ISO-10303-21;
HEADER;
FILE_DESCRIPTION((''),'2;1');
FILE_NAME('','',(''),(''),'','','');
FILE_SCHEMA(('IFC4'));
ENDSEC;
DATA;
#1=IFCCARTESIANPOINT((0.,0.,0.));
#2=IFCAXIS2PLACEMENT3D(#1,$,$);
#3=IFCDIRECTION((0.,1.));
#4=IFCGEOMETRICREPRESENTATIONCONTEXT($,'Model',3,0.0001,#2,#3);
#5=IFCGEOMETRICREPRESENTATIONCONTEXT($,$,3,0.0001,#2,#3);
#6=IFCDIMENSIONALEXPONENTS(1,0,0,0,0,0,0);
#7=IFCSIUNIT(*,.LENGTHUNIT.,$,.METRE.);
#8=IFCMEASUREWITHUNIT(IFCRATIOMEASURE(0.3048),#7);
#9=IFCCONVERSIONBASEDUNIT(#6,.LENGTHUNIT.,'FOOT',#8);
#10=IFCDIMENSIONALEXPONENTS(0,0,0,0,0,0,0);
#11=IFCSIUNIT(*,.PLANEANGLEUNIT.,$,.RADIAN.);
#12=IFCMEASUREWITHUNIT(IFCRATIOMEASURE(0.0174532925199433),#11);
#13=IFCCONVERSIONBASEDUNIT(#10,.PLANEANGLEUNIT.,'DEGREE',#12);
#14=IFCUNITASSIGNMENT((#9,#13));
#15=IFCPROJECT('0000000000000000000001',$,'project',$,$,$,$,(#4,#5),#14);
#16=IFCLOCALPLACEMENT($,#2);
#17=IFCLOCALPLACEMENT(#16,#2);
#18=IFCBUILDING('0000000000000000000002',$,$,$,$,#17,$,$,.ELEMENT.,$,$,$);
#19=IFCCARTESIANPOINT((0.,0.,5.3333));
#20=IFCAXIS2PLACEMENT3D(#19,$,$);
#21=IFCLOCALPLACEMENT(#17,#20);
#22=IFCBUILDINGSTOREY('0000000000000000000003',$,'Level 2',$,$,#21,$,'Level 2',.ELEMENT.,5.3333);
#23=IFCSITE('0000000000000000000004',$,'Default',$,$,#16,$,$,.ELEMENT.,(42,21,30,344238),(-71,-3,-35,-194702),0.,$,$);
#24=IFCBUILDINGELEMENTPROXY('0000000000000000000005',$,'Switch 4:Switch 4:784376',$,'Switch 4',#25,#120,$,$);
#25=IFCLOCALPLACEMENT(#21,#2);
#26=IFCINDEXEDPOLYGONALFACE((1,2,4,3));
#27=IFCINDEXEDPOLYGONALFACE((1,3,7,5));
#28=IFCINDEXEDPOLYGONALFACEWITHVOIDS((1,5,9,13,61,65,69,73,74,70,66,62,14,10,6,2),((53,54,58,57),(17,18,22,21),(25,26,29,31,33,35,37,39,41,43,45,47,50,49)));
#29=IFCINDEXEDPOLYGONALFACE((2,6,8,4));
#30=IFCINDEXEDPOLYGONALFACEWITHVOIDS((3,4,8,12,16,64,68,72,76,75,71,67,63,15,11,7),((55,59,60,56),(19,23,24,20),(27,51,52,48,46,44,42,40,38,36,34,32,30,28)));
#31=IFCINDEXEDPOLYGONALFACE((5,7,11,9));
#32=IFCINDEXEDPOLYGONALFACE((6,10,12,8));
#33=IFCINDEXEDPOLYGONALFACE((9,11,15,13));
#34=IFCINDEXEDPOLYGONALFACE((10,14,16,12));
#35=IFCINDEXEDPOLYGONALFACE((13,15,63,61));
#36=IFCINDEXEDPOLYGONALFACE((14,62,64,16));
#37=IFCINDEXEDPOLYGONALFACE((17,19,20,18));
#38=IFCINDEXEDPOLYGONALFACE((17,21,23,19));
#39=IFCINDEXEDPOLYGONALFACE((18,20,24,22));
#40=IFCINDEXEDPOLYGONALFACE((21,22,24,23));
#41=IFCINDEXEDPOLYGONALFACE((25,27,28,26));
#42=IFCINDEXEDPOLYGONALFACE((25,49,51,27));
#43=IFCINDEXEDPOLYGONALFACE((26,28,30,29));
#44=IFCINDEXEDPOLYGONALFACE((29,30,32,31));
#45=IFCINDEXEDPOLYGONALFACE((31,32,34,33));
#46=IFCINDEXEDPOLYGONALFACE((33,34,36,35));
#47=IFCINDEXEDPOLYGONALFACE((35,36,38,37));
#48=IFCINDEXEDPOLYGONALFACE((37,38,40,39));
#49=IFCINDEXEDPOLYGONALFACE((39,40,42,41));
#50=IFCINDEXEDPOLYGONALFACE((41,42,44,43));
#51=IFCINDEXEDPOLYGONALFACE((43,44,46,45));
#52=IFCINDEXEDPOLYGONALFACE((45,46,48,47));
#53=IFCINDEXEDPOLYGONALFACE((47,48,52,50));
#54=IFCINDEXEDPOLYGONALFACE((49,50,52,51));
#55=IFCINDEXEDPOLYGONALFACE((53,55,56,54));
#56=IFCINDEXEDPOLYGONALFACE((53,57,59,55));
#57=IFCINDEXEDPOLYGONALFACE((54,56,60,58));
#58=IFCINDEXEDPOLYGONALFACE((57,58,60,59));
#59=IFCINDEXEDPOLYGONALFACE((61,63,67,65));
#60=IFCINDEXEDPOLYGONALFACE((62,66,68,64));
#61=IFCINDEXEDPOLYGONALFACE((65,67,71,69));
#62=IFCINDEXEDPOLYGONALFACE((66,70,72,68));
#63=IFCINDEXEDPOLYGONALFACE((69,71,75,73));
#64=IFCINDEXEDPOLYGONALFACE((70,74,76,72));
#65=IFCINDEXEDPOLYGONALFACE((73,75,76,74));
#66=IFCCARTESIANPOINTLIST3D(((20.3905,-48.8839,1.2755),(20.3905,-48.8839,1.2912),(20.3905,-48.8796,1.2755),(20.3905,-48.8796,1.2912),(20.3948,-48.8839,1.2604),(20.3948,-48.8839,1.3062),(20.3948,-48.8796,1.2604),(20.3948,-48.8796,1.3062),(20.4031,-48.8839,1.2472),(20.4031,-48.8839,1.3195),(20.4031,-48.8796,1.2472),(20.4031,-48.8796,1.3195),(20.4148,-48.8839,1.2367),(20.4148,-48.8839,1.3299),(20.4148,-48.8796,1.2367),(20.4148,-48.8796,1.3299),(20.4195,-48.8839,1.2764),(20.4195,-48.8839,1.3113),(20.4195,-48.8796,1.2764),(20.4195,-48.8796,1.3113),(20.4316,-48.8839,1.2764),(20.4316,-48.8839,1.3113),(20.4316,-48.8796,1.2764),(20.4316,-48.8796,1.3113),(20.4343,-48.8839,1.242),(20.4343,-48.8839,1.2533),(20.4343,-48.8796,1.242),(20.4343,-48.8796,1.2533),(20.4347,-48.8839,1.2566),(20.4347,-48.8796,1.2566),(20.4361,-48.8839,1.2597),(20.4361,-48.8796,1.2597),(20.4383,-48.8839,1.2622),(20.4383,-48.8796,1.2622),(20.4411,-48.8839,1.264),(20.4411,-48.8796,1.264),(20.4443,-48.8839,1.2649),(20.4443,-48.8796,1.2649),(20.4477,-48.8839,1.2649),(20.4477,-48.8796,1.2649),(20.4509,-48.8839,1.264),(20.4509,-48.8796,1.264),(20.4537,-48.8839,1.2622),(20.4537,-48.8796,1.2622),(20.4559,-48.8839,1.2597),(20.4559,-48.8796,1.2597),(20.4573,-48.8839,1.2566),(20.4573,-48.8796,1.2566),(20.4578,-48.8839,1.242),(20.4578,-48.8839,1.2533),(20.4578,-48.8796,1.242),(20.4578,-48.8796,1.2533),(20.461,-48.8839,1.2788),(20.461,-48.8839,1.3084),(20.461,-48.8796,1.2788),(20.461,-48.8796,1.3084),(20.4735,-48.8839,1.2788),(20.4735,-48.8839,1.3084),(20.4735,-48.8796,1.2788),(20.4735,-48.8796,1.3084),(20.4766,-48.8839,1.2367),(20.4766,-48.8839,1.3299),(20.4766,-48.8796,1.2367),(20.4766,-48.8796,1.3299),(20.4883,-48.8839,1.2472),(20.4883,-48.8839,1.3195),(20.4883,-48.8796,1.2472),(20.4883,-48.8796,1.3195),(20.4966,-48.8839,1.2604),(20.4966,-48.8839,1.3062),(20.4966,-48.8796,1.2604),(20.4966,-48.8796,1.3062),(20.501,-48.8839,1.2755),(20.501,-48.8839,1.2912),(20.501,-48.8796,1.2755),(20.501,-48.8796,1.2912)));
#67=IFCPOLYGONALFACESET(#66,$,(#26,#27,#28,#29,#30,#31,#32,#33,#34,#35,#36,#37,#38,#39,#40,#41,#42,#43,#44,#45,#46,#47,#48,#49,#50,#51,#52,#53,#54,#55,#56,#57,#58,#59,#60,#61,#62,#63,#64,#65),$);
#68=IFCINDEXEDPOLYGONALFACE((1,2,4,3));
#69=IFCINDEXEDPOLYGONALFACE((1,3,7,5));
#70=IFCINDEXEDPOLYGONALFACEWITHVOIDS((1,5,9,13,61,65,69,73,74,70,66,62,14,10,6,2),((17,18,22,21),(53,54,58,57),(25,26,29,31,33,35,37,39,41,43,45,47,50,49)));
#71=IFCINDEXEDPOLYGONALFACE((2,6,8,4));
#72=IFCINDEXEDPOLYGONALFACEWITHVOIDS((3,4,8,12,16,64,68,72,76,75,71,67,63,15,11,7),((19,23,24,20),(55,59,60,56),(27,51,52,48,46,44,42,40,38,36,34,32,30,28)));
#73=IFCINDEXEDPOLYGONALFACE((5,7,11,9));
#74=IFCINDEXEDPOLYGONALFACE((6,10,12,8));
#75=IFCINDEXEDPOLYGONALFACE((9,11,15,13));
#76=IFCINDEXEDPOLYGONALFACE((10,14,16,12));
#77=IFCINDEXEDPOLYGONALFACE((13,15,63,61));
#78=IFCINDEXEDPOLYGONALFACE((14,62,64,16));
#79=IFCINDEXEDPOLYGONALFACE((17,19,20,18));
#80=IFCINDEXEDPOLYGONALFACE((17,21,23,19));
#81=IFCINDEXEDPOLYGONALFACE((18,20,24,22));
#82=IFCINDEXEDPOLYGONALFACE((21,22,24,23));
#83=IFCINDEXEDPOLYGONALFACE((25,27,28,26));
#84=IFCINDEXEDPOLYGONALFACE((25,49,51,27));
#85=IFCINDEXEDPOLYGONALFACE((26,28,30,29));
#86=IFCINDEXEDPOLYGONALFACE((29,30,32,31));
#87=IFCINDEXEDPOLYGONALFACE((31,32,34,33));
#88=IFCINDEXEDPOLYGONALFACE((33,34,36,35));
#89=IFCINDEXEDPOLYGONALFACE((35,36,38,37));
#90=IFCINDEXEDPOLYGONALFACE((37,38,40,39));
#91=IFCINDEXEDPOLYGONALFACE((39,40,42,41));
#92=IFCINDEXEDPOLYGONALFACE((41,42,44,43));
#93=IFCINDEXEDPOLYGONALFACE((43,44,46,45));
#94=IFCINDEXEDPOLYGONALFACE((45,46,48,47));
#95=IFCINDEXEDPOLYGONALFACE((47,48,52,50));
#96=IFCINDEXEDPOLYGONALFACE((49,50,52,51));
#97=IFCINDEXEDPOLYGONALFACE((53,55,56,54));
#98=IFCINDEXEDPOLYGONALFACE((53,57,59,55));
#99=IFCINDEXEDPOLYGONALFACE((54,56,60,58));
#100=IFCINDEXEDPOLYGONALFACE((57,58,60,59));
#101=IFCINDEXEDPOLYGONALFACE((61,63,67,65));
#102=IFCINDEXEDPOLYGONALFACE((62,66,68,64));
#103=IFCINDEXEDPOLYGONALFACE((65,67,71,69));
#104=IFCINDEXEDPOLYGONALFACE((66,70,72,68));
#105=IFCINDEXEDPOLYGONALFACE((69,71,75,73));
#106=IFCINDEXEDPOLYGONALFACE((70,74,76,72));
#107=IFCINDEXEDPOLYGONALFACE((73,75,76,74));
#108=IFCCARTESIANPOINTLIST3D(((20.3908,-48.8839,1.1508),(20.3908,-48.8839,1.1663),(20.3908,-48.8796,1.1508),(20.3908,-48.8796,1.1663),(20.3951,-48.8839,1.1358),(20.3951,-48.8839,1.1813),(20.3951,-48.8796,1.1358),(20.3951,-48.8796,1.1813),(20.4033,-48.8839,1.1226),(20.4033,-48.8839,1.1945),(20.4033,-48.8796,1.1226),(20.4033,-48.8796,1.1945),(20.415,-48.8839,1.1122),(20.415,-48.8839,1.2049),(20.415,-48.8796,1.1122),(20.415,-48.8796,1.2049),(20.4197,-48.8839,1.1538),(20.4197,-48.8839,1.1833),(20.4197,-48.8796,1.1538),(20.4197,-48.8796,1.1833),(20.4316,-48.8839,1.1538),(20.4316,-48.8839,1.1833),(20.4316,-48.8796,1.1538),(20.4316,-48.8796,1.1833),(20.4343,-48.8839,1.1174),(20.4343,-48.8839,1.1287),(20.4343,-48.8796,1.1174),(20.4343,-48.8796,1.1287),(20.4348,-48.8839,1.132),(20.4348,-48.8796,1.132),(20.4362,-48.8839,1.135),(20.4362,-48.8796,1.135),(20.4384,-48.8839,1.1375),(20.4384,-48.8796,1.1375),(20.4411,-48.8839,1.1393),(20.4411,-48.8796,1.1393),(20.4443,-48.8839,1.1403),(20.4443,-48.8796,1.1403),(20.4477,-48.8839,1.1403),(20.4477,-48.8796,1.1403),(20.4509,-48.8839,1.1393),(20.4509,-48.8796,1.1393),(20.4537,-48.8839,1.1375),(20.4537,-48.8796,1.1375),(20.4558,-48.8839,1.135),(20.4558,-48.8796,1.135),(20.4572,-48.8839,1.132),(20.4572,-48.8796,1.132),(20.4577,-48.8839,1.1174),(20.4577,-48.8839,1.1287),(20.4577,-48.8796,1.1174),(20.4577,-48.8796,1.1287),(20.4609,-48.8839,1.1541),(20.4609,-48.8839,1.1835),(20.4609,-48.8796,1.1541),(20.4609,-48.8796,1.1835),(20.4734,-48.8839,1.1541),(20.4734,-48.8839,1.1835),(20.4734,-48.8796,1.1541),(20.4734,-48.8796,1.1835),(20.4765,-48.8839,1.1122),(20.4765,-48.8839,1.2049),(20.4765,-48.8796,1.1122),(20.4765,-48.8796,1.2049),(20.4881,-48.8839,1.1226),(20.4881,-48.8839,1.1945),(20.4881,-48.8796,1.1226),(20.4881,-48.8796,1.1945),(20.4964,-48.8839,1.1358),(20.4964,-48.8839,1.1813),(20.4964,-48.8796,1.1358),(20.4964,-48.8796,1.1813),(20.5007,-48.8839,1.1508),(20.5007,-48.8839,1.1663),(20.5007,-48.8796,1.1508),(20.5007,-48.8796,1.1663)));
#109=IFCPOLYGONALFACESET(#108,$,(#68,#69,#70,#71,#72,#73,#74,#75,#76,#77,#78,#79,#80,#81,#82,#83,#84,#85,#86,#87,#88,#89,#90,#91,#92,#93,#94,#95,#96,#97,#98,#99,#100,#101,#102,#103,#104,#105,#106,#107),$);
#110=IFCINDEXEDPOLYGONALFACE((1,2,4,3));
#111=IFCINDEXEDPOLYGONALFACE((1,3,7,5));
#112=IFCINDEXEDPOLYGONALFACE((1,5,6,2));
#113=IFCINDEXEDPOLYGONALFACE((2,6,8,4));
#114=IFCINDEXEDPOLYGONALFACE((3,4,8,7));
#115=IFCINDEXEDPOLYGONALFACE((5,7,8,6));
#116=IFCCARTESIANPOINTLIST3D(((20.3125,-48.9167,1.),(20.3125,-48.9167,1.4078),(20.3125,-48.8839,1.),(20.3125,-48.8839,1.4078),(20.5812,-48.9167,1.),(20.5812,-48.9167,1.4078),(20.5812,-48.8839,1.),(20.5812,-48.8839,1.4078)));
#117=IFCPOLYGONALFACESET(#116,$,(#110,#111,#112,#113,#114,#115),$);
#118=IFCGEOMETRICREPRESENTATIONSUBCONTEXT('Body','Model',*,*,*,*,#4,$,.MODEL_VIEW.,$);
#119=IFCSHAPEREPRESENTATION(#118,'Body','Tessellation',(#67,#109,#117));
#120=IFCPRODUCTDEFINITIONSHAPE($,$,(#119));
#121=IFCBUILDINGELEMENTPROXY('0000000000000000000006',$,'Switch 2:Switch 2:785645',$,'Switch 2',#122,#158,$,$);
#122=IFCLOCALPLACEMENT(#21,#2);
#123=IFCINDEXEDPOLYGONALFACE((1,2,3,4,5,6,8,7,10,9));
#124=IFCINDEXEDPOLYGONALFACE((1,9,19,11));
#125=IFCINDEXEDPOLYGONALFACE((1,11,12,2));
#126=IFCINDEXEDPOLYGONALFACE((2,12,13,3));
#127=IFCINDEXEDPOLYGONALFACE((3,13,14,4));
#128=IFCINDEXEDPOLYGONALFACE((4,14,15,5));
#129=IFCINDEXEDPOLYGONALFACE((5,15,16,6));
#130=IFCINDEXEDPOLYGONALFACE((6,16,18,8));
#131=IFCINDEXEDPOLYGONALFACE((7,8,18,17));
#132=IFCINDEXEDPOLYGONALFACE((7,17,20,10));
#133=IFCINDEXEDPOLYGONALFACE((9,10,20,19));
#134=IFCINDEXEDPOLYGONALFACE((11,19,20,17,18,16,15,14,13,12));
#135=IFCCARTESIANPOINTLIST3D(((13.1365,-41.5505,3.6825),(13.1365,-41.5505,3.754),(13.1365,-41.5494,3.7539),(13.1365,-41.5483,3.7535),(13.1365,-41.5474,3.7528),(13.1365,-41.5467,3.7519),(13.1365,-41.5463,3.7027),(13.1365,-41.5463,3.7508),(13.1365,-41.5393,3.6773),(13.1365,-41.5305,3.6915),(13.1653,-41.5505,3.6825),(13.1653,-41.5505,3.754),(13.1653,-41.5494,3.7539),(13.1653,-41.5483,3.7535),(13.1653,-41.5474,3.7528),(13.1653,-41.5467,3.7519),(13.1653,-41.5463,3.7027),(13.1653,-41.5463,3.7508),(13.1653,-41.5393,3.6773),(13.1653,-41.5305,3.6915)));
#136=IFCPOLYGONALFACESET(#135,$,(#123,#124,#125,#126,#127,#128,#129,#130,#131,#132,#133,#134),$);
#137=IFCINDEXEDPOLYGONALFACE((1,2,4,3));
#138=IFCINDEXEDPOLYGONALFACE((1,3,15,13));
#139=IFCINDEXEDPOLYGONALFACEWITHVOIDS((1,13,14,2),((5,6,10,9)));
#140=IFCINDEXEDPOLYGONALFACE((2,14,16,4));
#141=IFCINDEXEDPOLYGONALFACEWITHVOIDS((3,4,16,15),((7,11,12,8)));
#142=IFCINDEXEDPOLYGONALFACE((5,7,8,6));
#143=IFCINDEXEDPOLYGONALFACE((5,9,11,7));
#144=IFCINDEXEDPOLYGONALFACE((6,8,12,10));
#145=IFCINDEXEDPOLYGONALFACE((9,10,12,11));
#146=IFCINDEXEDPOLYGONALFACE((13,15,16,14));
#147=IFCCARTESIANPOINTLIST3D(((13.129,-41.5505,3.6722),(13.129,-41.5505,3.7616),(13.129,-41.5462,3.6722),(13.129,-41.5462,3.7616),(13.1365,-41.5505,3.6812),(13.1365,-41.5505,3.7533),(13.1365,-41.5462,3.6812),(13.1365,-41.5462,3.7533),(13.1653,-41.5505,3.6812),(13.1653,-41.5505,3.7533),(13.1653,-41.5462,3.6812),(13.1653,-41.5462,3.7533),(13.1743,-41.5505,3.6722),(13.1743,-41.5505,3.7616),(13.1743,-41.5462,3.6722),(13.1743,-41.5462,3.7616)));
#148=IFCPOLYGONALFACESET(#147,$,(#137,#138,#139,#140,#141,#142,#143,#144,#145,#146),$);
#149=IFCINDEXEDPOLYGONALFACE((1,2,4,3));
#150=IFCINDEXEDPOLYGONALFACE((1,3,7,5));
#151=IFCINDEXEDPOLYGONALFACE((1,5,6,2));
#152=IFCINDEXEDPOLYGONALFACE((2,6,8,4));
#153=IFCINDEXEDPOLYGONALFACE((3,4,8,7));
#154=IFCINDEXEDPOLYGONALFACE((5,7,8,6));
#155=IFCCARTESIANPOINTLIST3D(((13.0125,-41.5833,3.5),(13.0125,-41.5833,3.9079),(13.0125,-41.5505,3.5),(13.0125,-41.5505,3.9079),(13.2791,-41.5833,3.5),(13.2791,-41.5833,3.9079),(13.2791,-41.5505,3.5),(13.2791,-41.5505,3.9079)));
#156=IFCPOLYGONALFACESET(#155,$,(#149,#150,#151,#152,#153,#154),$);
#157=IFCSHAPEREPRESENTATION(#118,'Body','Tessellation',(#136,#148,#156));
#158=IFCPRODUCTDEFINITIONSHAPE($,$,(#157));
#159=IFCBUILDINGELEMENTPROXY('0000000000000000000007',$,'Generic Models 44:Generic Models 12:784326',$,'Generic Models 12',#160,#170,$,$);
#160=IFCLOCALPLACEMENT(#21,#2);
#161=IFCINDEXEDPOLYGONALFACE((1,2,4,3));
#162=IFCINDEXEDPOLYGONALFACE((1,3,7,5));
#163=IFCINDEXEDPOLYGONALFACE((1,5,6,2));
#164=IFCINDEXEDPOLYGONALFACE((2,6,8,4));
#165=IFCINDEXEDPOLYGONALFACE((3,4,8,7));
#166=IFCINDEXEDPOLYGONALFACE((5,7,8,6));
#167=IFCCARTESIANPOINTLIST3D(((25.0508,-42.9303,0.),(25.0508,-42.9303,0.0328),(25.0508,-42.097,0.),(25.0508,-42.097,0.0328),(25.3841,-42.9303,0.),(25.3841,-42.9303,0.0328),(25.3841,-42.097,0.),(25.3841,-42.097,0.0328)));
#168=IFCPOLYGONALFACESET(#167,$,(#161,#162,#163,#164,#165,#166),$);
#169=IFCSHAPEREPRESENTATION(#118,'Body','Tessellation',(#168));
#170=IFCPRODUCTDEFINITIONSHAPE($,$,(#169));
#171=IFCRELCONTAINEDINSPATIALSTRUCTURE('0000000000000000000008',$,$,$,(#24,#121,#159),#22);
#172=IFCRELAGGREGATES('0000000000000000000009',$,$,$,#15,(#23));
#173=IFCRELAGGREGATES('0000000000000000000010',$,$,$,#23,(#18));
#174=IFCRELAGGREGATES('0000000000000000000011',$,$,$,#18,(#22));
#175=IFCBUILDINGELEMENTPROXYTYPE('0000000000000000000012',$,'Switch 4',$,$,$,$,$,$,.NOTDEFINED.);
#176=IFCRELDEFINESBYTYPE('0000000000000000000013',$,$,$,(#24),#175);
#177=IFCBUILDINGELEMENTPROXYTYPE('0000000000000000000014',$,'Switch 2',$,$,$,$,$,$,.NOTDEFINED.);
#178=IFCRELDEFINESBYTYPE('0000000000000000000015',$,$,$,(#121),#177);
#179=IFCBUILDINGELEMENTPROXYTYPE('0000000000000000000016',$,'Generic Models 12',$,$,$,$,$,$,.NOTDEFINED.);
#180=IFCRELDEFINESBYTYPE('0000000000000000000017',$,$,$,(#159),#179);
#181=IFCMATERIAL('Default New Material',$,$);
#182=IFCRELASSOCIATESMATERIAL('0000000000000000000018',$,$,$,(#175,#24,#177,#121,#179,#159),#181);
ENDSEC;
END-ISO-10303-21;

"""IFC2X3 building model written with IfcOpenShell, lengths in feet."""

from ifc_helpers import new_model, entity, si_unit, converted_unit, direction, frame, frame_2d, origin, origin_2d_with_axis, place, context, subcontext, project, spatial, polyline, circle_curve, parameter, trimmed, segment, composite_curve, rectangle, outline, extrude, source, transform, mapped, material, type_object, type_shapes, element, save


model = new_model("IFC2X3")

# Units and contexts
model_context = context("Model", 3, precision=0.0001, world=origin(), true_north=direction((0.0, 1.0)))
context_of_model = context(None, 3, precision=0.0001, world=origin(), true_north=direction((0.0, 1.0)))
body_context = subcontext(model_context, "Body", "Model", "MODEL_VIEW")
ifc_project = project(units=[converted_unit("LENGTHUNIT", "FOOT", entity("IfcRatioMeasure", 0.3048), si_unit("LENGTHUNIT", "METRE"), dimensions=[1, 0, 0, 0, 0, 0, 0]), converted_unit("PLANEANGLEUNIT", "DEGREE", entity("IfcRatioMeasure", 0.0174532925199433), si_unit("PLANEANGLEUNIT", "RADIAN"), dimensions=[0, 0, 0, 0, 0, 0, 0])], contexts=[model_context, context_of_model])

# Site, building, storey
site_placement = place(None, origin())
site = spatial("IfcSite", under=ifc_project, at=site_placement, Name="Default", CompositionType="ELEMENT", RefLatitude=(42, 21, 30, 344238), RefLongitude=(-71, -3, -35, -194702), RefElevation=0.0)
building_placement = place(site_placement, origin())
building = spatial("IfcBuilding", under=site, at=building_placement, CompositionType="ELEMENT")
storey_placement = place(building_placement, frame((0.0, 0.0, 5.3333)))
storey = spatial("IfcBuildingStorey", under=building, at=storey_placement, Name="Level 2", LongName="Level 2", CompositionType="ELEMENT", Elevation=5.3333)

# Shared definitions
ifc_material_1 = material(Name="Default New Material")

# Building element proxies
building_element_proxy_type_1 = type_object("IfcBuildingElementProxyType", Name="Switch 4", PredefinedType="NOTDEFINED", material=ifc_material_1)
shared_shape_1 = source(origin(), body_context, "Body", "SweptSolid", [
    extrude(outline(composite_curve([segment(polyline([(-0.0309, -0.0466), (0.0309, -0.0466)]), True, "CONTINUOUS"), segment(trimmed(circle_curve(frame_2d((-0.0003, 0.0), x_axis=(-1.0, 0.0)), 0.0561), [parameter(123.794741)], [parameter(236.205259)], True, "PARAMETER"), True, "CONTINUOUS"), segment(polyline([(0.0309, 0.0466), (-0.0309, 0.0466)]), True, "CONTINUOUS"), segment(trimmed(circle_curve(frame_2d((0.0003, 0.0), x_axis=(1.0, 0.0)), 0.0561), [parameter(123.794741)], [parameter(236.205259)], True, "PARAMETER"), True, "CONTINUOUS")], self_intersect=False), holes=[polyline([(0.0142, 0.0279), (0.0262, 0.0279), (0.0262, -0.0069), (0.0142, -0.0069), (0.0142, 0.0279)]), polyline([(-0.0153, 0.025), (-0.0153, -0.0045), (-0.0278, -0.0045), (-0.0278, 0.025), (-0.0153, 0.025)]), composite_curve([segment(polyline([(-0.012, -0.0413), (-0.012, -0.03)]), True, "CONTINUOUS"), segment(trimmed(circle_curve(frame_2d((-0.0003, -0.03), x_axis=(-1.0, 0.0)), 0.0117), [parameter(180.0)], [parameter(0.0)], True, "PARAMETER"), False, "CONTINUOUS"), segment(polyline([(0.0115, -0.03), (0.0115, -0.0413)]), True, "CONTINUOUS"), segment(polyline([(0.0115, -0.0413), (-0.012, -0.0413)]), True, "CONTINUOUS")], self_intersect=False)]), frame((-0.0011, 0.0328, 0.2833), z_axis=(0.0, 1.0, 0.0), x_axis=(-1.0, 0.0, 0.0)), (0.0, 0.0, 1.0), 0.0042),
    extrude(outline(composite_curve([segment(polyline([(-0.0308, -0.0464), (0.0308, -0.0464)]), True, "CONTINUOUS"), segment(trimmed(circle_curve(frame_2d((-0.0003, 0.0), x_axis=(-1.0, 0.0)), 0.0558), [parameter(123.794741)], [parameter(236.205259)], True, "PARAMETER"), True, "CONTINUOUS"), segment(polyline([(0.0308, 0.0464), (-0.0308, 0.0464)]), True, "CONTINUOUS"), segment(trimmed(circle_curve(frame_2d((0.0003, 0.0), x_axis=(1.0, 0.0)), 0.0558), [parameter(123.794741)], [parameter(236.205259)], True, "PARAMETER"), True, "CONTINUOUS")], self_intersect=False), holes=[polyline([(0.0141, 0.0247), (0.026, 0.0247), (0.026, -0.0047), (0.0141, -0.0047), (0.0141, 0.0247)]), polyline([(-0.0152, 0.0249), (-0.0152, -0.0045), (-0.0277, -0.0045), (-0.0277, 0.0249), (-0.0152, 0.0249)]), composite_curve([segment(polyline([(-0.012, -0.0411), (-0.012, -0.0299)]), True, "CONTINUOUS"), segment(trimmed(circle_curve(frame_2d((-0.0003, -0.0299), x_axis=(-1.0, 0.0)), 0.0117), [parameter(180.0)], [parameter(0.0)], True, "PARAMETER"), False, "CONTINUOUS"), segment(polyline([(0.0114, -0.0299), (0.0114, -0.0411)]), True, "CONTINUOUS"), segment(polyline([(0.0114, -0.0411), (-0.012, -0.0411)]), True, "CONTINUOUS")], self_intersect=False)]), frame((-0.0011, 0.0328, 0.1586), z_axis=(0.0, 1.0, 0.0), x_axis=(-1.0, 0.0, 0.0)), (0.0, 0.0, 1.0), 0.0042),
    extrude(rectangle(XDim=0.0328, YDim=0.2687, at=origin_2d_with_axis()), frame((0.0, 0.0164, 0.0), z_axis=(0.0, 0.0, 1.0), x_axis=(0.0, -1.0, 0.0)), (0.0, 0.0, 1.0), 0.4078),
])
type_shapes(building_element_proxy_type_1, [shared_shape_1])
proxy_1_placement = place(storey_placement, frame((20.4468, -48.9167, 1.0)))
element("IfcBuildingElementProxy", 1, at=proxy_1_placement, inside=storey, type_object=building_element_proxy_type_1, material=ifc_material_1, Name="Switch 4:Switch 4:784376", ObjectType="Switch 4", context=body_context, shape_type="MappedRepresentation", body=[
    mapped(shared_shape_1, transform((0.0, 0.0, 0.0), scale=1.0)),
])
building_element_proxy_type_2 = type_object("IfcBuildingElementProxyType", Name="Switch 2", PredefinedType="NOTDEFINED", material=ifc_material_1)
shared_shape_2 = source(origin(), body_context, "Body", "SweptSolid", [
    extrude(outline(composite_curve([segment(polyline([(-0.0252, -0.0211), (-0.0084, -0.0211)]), True, "CONTINUOUS"), segment(polyline([(-0.0084, -0.0211), (-0.0073, -0.0017)]), True, "CONTINUOUS"), segment(polyline([(-0.0073, -0.0017), (0.0336, 0.0237)]), True, "CONTINUOUS"), segment(trimmed(circle_curve(frame_2d((0.0308, 0.0266), x_axis=(0.848706, 0.528865)), 0.004), [parameter(281.689503)], [parameter(4.471238)], True, "PARAMETER"), True, "CONTINUOUS"), segment(polyline([(0.034, 0.029), (-0.0267, -0.0088)]), True, "CONTINUOUS"), segment(polyline([(-0.0267, -0.0088), (-0.0252, -0.0211)]), True, "CONTINUOUS")], self_intersect=False)), frame((-0.0093, 0.0394, 0.2098), z_axis=(1.0, 0.0, 0.0), x_axis=(0.0, 0.528865, 0.848706)), (0.0, 0.0, 1.0), 0.0287),
    extrude(outline(polyline([(-0.0447, -0.0227), (0.0447, -0.0227), (0.0447, 0.0227), (-0.0447, 0.0227), (-0.0447, -0.0227)]), holes=[polyline([(-0.0364, -0.0136), (-0.0364, 0.0151), (0.0357, 0.0151), (0.0357, -0.0136), (-0.0364, -0.0136)])]), frame((0.0058, 0.0329, 0.2169), z_axis=(0.0, 1.0, 0.0), x_axis=(0.0, 0.0, -1.0)), (0.0, 0.0, 1.0), 0.0042),
    extrude(rectangle(XDim=0.0329, YDim=0.2666, at=origin_2d_with_axis()), frame((-0.0001, 0.0164, 0.0), z_axis=(0.0, 0.0, 1.0), x_axis=(0.0, -1.0, 0.0)), (0.0, 0.0, 1.0), 0.4079),
])
type_shapes(building_element_proxy_type_2, [shared_shape_2])
proxy_2_placement = place(storey_placement, frame((13.1458, -41.5833, 3.5)))
element("IfcBuildingElementProxy", 2, at=proxy_2_placement, inside=storey, type_object=building_element_proxy_type_2, material=ifc_material_1, Name="Switch 2:Switch 2:785645", ObjectType="Switch 2", context=body_context, shape_type="MappedRepresentation", body=[
    mapped(shared_shape_2, transform((0.0, 0.0, 0.0), scale=1.0)),
])
building_element_proxy_type_3 = type_object("IfcBuildingElementProxyType", Name="Generic Models 12", PredefinedType="NOTDEFINED", material=ifc_material_1)
shared_shape_3 = source(origin(), body_context, "Body", "SweptSolid", [
    extrude(rectangle(XDim=0.8333, YDim=0.3333, at=frame_2d((0.0, 0.0), x_axis=(1.0, 0.0))), frame((0.1667, 0.4167, 0.0), z_axis=(0.0, 0.0, 1.0), x_axis=(0.0, 1.0, 0.0)), (0.0, 0.0, 1.0), 0.0328),
])
type_shapes(building_element_proxy_type_3, [shared_shape_3])
proxy_3_placement = place(storey_placement, frame((25.0508, -42.9303, 0.0)))
element("IfcBuildingElementProxy", 3, at=proxy_3_placement, inside=storey, type_object=building_element_proxy_type_3, material=ifc_material_1, Name="Generic Models 44:Generic Models 12:784326", ObjectType="Generic Models 12", context=body_context, shape_type="MappedRepresentation", body=[
    mapped(shared_shape_3, transform((0.0, 0.0, 0.0), scale=1.0)),
])

save(model, "model.ifc")
